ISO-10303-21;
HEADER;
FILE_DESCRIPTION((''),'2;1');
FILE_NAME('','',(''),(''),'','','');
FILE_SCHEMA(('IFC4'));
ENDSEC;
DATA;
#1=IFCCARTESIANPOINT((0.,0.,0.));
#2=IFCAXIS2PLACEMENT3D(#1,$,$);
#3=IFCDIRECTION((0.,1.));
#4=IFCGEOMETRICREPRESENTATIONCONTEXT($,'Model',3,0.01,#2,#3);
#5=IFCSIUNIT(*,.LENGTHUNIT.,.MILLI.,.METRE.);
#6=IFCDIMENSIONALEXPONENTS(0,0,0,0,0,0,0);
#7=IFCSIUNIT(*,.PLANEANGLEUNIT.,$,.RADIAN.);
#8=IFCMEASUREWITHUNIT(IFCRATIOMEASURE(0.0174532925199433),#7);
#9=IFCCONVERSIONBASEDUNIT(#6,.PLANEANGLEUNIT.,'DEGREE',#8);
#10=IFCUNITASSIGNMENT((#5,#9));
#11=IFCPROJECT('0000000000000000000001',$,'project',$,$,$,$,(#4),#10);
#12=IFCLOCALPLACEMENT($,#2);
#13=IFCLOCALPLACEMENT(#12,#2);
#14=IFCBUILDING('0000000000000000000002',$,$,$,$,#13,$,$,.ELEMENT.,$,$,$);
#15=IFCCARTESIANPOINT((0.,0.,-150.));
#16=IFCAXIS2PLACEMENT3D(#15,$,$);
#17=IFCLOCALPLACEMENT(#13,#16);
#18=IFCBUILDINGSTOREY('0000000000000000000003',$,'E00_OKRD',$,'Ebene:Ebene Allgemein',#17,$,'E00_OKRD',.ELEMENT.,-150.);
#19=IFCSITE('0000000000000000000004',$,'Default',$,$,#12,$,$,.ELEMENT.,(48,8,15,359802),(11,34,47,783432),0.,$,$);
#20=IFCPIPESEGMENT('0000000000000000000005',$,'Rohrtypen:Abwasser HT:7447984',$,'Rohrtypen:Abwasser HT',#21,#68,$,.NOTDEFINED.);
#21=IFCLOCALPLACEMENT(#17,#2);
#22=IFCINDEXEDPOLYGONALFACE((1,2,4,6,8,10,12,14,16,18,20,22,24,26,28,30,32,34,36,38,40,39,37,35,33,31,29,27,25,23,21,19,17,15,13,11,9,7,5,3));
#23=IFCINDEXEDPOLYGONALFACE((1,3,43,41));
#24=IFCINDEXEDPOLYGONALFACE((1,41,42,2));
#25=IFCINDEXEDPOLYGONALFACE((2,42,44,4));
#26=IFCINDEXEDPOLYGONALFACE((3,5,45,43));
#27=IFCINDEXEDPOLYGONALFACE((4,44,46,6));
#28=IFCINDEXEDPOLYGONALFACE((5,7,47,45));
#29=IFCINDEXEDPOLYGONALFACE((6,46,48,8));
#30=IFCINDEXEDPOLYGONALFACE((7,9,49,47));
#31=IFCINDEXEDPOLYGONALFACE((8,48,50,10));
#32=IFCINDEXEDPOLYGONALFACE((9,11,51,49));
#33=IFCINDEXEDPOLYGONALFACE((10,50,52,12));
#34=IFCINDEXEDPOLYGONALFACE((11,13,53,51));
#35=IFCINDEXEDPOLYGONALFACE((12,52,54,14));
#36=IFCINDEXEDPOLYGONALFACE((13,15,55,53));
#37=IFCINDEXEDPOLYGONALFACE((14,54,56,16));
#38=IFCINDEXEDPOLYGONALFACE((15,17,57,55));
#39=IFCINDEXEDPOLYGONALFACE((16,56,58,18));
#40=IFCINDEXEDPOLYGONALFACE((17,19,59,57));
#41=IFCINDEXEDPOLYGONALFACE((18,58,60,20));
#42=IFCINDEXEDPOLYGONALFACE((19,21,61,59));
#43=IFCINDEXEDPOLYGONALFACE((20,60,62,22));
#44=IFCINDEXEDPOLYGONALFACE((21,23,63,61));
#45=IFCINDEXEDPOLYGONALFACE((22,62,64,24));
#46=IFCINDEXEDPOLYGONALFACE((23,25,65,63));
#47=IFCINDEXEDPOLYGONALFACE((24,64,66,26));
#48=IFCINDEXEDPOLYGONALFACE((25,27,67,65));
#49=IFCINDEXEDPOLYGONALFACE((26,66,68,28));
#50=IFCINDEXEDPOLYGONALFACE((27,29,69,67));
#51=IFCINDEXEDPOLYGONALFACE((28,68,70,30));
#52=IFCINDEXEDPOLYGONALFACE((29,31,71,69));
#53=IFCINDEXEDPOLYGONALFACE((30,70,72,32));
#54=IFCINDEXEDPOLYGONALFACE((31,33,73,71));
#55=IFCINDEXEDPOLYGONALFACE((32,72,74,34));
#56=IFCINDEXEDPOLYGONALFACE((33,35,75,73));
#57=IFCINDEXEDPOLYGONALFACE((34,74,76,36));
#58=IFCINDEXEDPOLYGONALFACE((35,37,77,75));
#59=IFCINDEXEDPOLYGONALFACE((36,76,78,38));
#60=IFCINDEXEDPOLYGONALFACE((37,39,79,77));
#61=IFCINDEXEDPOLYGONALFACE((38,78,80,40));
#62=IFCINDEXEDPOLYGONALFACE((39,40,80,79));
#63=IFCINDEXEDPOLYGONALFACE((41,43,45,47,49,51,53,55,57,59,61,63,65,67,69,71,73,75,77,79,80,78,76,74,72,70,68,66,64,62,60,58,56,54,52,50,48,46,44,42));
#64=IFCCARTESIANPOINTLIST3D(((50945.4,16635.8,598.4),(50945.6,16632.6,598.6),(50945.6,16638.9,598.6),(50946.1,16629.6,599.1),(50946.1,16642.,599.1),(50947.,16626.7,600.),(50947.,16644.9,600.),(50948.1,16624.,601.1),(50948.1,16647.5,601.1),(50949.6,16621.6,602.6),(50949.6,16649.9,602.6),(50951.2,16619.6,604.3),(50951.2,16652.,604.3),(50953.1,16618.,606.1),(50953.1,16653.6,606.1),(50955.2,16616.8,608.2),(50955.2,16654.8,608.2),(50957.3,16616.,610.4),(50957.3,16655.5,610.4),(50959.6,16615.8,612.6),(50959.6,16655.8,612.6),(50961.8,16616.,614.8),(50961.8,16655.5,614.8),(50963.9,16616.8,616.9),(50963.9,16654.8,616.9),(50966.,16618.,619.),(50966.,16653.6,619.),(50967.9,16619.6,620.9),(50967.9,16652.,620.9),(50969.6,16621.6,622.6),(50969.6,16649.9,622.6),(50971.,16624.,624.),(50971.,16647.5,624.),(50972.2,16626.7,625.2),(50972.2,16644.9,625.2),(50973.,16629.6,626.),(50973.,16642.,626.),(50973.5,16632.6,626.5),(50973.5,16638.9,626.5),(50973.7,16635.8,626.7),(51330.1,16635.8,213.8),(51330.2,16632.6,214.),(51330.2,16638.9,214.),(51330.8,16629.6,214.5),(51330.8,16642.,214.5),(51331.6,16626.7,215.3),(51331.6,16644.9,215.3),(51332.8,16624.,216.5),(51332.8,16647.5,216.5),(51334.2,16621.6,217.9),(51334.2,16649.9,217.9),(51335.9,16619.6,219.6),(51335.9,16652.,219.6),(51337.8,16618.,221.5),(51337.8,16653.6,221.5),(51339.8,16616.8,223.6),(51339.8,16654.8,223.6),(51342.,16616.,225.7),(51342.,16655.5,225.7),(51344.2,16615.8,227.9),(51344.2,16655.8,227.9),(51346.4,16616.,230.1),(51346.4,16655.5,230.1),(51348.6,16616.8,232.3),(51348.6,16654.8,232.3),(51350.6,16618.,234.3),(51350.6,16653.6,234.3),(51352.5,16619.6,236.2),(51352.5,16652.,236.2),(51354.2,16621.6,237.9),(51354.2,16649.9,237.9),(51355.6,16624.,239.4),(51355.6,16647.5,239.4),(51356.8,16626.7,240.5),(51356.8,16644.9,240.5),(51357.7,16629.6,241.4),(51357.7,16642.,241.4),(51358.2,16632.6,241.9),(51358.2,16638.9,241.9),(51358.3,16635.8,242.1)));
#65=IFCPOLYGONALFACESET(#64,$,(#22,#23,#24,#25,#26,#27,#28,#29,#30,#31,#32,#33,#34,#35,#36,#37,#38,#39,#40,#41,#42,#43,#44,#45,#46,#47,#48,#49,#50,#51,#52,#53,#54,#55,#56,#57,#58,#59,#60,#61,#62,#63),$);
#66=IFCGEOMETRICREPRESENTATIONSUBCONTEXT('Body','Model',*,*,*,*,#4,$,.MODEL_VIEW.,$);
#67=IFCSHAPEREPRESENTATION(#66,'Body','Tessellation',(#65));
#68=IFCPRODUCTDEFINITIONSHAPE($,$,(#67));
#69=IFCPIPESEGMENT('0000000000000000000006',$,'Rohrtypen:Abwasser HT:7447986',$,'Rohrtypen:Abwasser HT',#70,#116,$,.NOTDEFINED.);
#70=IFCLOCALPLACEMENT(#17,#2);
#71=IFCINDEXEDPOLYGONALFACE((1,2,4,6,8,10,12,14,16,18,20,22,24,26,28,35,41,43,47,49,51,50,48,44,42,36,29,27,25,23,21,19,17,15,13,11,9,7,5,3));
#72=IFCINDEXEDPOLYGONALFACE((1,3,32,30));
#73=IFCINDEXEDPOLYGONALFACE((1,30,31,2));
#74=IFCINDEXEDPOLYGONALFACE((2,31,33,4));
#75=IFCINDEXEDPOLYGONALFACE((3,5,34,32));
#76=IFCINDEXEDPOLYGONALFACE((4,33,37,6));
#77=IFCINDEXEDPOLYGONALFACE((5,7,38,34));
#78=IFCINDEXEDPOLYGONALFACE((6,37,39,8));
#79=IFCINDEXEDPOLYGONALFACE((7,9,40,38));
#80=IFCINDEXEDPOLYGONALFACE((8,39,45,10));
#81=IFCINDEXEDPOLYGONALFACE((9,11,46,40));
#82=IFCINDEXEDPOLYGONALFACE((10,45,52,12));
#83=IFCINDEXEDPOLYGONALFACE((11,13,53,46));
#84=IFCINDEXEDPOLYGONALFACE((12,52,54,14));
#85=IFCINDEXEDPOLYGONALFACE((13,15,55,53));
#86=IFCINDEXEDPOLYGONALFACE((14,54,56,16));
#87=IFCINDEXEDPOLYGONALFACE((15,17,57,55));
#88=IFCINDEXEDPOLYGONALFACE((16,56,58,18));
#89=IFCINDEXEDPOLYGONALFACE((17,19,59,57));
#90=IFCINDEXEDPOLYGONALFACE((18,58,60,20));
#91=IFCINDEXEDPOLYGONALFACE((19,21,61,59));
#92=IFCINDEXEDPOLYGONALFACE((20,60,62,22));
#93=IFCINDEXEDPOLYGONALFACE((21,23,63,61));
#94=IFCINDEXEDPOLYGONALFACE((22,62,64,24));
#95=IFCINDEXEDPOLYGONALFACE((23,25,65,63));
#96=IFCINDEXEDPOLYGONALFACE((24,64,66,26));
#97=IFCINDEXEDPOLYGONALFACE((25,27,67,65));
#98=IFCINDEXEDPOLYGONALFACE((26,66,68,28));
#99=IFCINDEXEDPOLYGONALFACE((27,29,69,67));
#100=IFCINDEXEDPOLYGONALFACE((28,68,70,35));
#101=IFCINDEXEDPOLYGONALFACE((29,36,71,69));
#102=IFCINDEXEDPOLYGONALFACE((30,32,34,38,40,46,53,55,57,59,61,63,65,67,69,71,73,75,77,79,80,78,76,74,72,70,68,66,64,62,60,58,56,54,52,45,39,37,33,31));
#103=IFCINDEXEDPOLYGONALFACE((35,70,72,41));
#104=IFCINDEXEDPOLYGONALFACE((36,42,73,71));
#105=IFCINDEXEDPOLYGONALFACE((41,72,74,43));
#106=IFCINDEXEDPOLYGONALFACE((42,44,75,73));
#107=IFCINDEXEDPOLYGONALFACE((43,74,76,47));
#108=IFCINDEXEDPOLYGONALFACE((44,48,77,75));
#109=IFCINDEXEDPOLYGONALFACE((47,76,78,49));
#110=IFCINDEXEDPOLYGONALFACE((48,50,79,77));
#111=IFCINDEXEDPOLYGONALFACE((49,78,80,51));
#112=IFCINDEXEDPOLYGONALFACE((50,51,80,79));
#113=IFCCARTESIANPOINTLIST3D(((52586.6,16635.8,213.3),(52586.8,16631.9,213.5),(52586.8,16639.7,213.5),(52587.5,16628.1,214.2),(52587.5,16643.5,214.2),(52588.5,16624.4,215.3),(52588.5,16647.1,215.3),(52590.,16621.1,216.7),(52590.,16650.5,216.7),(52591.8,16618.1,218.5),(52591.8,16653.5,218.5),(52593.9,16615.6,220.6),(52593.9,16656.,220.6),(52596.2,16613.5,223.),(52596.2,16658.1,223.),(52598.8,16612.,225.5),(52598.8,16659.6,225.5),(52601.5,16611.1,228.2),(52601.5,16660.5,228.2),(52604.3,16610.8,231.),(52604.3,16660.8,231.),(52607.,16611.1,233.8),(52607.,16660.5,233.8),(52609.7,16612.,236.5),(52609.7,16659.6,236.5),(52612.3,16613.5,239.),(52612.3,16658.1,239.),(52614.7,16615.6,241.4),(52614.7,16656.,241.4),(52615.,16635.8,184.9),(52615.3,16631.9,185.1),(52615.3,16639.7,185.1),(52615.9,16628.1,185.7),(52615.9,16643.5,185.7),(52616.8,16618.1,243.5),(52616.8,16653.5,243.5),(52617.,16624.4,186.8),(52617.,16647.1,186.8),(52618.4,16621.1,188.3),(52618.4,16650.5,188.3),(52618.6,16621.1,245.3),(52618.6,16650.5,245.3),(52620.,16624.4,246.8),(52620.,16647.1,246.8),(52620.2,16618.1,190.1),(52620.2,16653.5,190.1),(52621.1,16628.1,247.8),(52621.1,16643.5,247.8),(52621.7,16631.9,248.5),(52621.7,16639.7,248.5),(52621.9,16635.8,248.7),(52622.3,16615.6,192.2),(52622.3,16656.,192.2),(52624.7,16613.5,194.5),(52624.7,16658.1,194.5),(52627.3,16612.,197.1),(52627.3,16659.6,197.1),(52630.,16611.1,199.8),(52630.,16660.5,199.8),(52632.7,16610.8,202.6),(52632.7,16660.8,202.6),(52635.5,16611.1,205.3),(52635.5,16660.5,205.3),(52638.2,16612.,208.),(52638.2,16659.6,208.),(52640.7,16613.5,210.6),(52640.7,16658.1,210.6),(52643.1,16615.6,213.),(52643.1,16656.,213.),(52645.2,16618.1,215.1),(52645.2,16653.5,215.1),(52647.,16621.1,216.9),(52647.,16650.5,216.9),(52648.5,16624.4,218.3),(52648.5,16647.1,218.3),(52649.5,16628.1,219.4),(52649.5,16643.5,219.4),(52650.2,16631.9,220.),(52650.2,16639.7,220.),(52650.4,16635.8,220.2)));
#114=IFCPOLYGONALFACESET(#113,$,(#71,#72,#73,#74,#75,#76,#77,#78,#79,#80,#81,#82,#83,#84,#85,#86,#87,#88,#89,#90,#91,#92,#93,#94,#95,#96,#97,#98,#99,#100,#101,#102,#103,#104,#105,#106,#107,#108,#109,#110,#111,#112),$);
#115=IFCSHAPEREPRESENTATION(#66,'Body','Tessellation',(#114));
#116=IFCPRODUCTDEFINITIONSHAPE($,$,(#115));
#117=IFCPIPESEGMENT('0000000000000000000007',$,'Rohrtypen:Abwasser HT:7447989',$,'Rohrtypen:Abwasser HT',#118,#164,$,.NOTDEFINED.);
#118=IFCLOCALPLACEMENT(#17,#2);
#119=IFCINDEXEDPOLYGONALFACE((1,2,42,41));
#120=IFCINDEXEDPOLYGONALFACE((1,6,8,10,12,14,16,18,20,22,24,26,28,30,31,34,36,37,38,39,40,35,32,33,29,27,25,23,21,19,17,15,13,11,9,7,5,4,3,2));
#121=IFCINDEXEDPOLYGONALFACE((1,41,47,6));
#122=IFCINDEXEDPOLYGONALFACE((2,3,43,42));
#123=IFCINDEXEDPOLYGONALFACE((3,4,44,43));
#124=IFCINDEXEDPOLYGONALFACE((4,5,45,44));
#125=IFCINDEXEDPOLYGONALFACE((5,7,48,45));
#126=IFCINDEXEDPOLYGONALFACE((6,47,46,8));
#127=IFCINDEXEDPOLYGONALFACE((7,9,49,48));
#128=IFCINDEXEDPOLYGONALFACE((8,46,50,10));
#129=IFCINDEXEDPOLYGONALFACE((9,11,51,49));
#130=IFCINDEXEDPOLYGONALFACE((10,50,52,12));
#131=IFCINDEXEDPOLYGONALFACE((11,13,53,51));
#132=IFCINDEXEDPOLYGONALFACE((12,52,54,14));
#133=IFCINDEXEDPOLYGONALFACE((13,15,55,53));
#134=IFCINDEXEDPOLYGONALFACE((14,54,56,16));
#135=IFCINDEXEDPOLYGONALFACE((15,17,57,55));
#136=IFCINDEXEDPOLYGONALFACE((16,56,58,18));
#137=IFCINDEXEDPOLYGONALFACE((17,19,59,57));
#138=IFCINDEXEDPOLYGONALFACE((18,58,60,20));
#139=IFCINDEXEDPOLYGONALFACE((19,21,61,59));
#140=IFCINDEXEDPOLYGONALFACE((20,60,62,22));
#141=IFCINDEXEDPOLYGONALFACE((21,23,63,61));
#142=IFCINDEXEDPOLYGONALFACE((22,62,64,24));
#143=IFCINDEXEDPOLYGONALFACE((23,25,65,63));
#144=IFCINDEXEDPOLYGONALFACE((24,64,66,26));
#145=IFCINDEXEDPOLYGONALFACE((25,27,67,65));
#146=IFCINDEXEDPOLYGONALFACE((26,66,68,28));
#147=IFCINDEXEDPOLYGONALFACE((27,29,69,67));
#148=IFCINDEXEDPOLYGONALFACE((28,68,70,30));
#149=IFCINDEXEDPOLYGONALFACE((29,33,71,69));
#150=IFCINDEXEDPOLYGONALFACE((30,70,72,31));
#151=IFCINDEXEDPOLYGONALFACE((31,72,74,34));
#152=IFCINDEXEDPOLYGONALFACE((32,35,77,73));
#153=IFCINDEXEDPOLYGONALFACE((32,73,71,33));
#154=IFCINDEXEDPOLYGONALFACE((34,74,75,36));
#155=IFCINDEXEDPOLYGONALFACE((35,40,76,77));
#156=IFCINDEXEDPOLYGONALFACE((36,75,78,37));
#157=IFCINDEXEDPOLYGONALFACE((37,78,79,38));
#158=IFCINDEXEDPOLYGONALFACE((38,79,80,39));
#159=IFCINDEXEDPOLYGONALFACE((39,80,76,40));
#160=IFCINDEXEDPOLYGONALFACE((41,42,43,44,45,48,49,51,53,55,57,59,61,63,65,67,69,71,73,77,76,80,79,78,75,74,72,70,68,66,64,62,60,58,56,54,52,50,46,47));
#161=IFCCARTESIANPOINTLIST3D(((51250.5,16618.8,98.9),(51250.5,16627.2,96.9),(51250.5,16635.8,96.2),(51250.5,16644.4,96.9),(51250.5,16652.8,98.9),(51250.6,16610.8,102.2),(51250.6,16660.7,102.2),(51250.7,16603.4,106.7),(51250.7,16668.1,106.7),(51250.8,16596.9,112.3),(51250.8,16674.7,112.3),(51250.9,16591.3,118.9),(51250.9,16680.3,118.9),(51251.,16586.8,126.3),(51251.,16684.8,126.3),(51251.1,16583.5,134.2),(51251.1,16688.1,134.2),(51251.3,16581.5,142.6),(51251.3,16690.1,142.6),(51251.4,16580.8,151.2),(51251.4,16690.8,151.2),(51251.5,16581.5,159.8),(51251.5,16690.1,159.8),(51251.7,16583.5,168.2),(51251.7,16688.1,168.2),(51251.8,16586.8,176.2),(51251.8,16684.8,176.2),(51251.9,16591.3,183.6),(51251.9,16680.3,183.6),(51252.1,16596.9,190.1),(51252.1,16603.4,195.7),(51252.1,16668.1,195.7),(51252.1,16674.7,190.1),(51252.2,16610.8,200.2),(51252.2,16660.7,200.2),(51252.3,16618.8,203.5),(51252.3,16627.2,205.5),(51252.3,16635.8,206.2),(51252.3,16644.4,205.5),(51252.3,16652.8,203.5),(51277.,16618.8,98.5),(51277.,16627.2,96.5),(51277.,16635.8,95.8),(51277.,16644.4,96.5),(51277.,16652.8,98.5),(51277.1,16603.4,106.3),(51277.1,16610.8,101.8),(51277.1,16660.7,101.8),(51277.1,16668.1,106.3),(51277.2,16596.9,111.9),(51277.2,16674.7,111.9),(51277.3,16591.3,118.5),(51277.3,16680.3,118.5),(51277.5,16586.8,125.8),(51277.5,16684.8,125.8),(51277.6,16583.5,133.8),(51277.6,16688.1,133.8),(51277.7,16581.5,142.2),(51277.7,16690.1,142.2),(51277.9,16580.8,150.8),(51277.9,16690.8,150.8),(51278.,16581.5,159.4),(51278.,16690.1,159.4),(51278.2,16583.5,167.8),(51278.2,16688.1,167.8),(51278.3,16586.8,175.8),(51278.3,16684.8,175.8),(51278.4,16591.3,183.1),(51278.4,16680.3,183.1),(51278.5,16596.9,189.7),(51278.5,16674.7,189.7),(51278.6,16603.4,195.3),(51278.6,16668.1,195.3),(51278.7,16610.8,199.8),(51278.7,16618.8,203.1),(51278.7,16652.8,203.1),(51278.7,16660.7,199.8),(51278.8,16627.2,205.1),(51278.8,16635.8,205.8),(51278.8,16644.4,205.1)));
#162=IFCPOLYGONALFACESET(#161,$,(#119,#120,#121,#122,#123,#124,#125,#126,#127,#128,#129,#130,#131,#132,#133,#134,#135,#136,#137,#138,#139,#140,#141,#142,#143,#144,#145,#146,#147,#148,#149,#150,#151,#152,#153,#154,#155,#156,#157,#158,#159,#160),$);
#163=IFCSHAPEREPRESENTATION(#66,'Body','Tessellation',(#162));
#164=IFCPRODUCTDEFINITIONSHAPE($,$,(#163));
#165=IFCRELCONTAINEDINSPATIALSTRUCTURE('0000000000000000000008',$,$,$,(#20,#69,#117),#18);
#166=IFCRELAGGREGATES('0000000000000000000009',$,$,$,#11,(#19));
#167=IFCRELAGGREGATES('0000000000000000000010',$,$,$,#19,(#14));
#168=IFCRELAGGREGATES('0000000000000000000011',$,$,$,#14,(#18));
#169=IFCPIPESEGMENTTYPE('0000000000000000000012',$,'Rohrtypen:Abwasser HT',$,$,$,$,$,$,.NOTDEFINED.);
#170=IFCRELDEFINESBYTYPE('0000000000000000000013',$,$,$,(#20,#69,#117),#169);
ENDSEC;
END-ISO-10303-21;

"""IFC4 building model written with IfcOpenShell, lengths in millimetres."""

from ifc_helpers import new_model, entity, si_unit, converted_unit, direction, frame, origin, place, context, subcontext, project, spatial, indexed_curve, outline, extrude, type_object, element, save


model = new_model("IFC4")

# Units and contexts
model_context = context("Model", 3, precision=0.01, world=origin(), true_north=direction((0.0, 1.0)))
body_context = subcontext(model_context, "Body", "Model", "MODEL_VIEW")
ifc_project = project(units=[si_unit("LENGTHUNIT", "METRE", prefix="MILLI"), converted_unit("PLANEANGLEUNIT", "DEGREE", entity("IfcRatioMeasure", 0.0174532925199433), si_unit("PLANEANGLEUNIT", "RADIAN"), dimensions=[0, 0, 0, 0, 0, 0, 0])], contexts=[model_context])

# Site, building, storey
site_placement = place(None, origin())
site = spatial("IfcSite", under=ifc_project, at=site_placement, Name="Default", CompositionType="ELEMENT", RefLatitude=(48, 8, 15, 359802), RefLongitude=(11, 34, 47, 783432), RefElevation=0.0)
building_placement = place(site_placement, origin())
building = spatial("IfcBuilding", under=site, at=building_placement, CompositionType="ELEMENT")
storey_placement = place(building_placement, frame((0.0, 0.0, -150.0)))
storey = spatial("IfcBuildingStorey", under=building, at=storey_placement, Name="E00_OKRD", ObjectType="Ebene:Ebene Allgemein", LongName="E00_OKRD", CompositionType="ELEMENT", Elevation=-150.0)

# Pipe segments
pipe_segment_type_1 = type_object("IfcPipeSegmentType", Name="Rohrtypen:Abwasser HT", PredefinedType="NOTDEFINED")
pipe_segment_1_placement = place(storey_placement, origin())
element("IfcPipeSegment", 1, at=pipe_segment_1_placement, inside=storey, type_object=pipe_segment_type_1, Name="Rohrtypen:Abwasser HT:7447984", ObjectType="Rohrtypen:Abwasser HT", PredefinedType="NOTDEFINED", context=body_context, shape_type="SweptSolid", body=[
    extrude(outline(indexed_curve([(20.0, 0.0), (19.8, 3.1), (19.0, 6.2), (17.8, 9.1), (16.2, 11.8), (14.1, 14.1), (11.8, 16.2), (9.1, 17.8), (6.2, 19.0), (3.1, 19.8), (0.0, 20.0), (-3.1, 19.8), (-6.2, 19.0), (-9.1, 17.8), (-11.8, 16.2), (-14.1, 14.1), (-16.2, 11.8), (-17.8, 9.1), (-19.0, 6.2), (-19.8, 3.1), (-20.0, 0.0), (-19.8, -3.1), (-19.0, -6.2), (-17.8, -9.1), (-16.2, -11.8), (-14.1, -14.1), (-11.8, -16.2), (-9.1, -17.8), (-6.2, -19.0), (-3.1, -19.8), (0.0, -20.0), (3.1, -19.8), (6.2, -19.0), (9.1, -17.8), (11.8, -16.2), (14.1, -14.1), (16.2, -11.8), (17.8, -9.1), (19.0, -6.2), (19.8, -3.1), (20.0, 0.0)], self_intersect=False)), frame((51344.2, 16635.8, 227.9), z_axis=(-0.707107, 0.0, 0.707107), x_axis=(0.0, -1.0, 0.0)), (0.0, 0.0, 1.0), 544.0),
])
pipe_segment_2_placement = place(storey_placement, origin())
element("IfcPipeSegment", 2, at=pipe_segment_2_placement, inside=storey, type_object=pipe_segment_type_1, Name="Rohrtypen:Abwasser HT:7447986", ObjectType="Rohrtypen:Abwasser HT", PredefinedType="NOTDEFINED", context=body_context, shape_type="SweptSolid", body=[
    extrude(outline(indexed_curve([(25.0, 0.0), (24.7, 3.9), (23.8, 7.7), (22.3, 11.3), (20.2, 14.7), (17.7, 17.7), (14.7, 20.2), (11.3, 22.3), (7.7, 23.8), (3.9, 24.7), (0.0, 25.0), (-3.9, 24.7), (-7.7, 23.8), (-11.3, 22.3), (-14.7, 20.2), (-17.7, 17.7), (-20.2, 14.7), (-22.3, 11.3), (-23.8, 7.7), (-24.7, 3.9), (-25.0, 0.0), (-24.7, -3.9), (-23.8, -7.7), (-22.3, -11.3), (-20.2, -14.7), (-17.7, -17.7), (-14.7, -20.2), (-11.3, -22.3), (-7.7, -23.8), (-3.9, -24.7), (0.0, -25.0), (3.9, -24.7), (7.7, -23.8), (11.3, -22.3), (14.7, -20.2), (17.7, -17.7), (20.2, -14.7), (22.3, -11.3), (23.8, -7.7), (24.7, -3.9), (25.0, 0.0)], self_intersect=False)), frame((52632.7, 16635.8, 202.6), z_axis=(-0.707107, 0.0, 0.707107), x_axis=(0.0, 1.0, 0.0)), (0.0, 0.0, 1.0), 40.2),
])
pipe_segment_3_placement = place(storey_placement, origin())
element("IfcPipeSegment", 3, at=pipe_segment_3_placement, inside=storey, type_object=pipe_segment_type_1, Name="Rohrtypen:Abwasser HT:7447989", ObjectType="Rohrtypen:Abwasser HT", PredefinedType="NOTDEFINED", context=body_context, shape_type="SweptSolid", body=[
    extrude(outline(indexed_curve([(55.0, 0.0), (54.3, 8.6), (52.3, 17.0), (49.0, 25.0), (44.5, 32.3), (38.9, 38.9), (32.3, 44.5), (25.0, 49.0), (17.0, 52.3), (8.6, 54.3), (0.0, 55.0), (-8.6, 54.3), (-17.0, 52.3), (-25.0, 49.0), (-32.3, 44.5), (-38.9, 38.9), (-44.5, 32.3), (-49.0, 25.0), (-52.3, 17.0), (-54.3, 8.6), (-55.0, 0.0), (-54.3, -8.6), (-52.3, -17.0), (-49.0, -25.0), (-44.5, -32.3), (-38.9, -38.9), (-32.3, -44.5), (-25.0, -49.0), (-17.0, -52.3), (-8.6, -54.3), (0.0, -55.0), (8.6, -54.3), (17.0, -52.3), (25.0, -49.0), (32.3, -44.5), (38.9, -38.9), (44.5, -32.3), (49.0, -25.0), (52.3, -17.0), (54.3, -8.6), (55.0, 0.0)], self_intersect=False)), frame((51251.4, 16635.8, 151.2), z_axis=(0.999862, 0.0, -0.016604), x_axis=(0.0, 1.0, 0.0)), (0.0, 0.0, 1.0), 26.5),
])

save(model, "model.ifc")
